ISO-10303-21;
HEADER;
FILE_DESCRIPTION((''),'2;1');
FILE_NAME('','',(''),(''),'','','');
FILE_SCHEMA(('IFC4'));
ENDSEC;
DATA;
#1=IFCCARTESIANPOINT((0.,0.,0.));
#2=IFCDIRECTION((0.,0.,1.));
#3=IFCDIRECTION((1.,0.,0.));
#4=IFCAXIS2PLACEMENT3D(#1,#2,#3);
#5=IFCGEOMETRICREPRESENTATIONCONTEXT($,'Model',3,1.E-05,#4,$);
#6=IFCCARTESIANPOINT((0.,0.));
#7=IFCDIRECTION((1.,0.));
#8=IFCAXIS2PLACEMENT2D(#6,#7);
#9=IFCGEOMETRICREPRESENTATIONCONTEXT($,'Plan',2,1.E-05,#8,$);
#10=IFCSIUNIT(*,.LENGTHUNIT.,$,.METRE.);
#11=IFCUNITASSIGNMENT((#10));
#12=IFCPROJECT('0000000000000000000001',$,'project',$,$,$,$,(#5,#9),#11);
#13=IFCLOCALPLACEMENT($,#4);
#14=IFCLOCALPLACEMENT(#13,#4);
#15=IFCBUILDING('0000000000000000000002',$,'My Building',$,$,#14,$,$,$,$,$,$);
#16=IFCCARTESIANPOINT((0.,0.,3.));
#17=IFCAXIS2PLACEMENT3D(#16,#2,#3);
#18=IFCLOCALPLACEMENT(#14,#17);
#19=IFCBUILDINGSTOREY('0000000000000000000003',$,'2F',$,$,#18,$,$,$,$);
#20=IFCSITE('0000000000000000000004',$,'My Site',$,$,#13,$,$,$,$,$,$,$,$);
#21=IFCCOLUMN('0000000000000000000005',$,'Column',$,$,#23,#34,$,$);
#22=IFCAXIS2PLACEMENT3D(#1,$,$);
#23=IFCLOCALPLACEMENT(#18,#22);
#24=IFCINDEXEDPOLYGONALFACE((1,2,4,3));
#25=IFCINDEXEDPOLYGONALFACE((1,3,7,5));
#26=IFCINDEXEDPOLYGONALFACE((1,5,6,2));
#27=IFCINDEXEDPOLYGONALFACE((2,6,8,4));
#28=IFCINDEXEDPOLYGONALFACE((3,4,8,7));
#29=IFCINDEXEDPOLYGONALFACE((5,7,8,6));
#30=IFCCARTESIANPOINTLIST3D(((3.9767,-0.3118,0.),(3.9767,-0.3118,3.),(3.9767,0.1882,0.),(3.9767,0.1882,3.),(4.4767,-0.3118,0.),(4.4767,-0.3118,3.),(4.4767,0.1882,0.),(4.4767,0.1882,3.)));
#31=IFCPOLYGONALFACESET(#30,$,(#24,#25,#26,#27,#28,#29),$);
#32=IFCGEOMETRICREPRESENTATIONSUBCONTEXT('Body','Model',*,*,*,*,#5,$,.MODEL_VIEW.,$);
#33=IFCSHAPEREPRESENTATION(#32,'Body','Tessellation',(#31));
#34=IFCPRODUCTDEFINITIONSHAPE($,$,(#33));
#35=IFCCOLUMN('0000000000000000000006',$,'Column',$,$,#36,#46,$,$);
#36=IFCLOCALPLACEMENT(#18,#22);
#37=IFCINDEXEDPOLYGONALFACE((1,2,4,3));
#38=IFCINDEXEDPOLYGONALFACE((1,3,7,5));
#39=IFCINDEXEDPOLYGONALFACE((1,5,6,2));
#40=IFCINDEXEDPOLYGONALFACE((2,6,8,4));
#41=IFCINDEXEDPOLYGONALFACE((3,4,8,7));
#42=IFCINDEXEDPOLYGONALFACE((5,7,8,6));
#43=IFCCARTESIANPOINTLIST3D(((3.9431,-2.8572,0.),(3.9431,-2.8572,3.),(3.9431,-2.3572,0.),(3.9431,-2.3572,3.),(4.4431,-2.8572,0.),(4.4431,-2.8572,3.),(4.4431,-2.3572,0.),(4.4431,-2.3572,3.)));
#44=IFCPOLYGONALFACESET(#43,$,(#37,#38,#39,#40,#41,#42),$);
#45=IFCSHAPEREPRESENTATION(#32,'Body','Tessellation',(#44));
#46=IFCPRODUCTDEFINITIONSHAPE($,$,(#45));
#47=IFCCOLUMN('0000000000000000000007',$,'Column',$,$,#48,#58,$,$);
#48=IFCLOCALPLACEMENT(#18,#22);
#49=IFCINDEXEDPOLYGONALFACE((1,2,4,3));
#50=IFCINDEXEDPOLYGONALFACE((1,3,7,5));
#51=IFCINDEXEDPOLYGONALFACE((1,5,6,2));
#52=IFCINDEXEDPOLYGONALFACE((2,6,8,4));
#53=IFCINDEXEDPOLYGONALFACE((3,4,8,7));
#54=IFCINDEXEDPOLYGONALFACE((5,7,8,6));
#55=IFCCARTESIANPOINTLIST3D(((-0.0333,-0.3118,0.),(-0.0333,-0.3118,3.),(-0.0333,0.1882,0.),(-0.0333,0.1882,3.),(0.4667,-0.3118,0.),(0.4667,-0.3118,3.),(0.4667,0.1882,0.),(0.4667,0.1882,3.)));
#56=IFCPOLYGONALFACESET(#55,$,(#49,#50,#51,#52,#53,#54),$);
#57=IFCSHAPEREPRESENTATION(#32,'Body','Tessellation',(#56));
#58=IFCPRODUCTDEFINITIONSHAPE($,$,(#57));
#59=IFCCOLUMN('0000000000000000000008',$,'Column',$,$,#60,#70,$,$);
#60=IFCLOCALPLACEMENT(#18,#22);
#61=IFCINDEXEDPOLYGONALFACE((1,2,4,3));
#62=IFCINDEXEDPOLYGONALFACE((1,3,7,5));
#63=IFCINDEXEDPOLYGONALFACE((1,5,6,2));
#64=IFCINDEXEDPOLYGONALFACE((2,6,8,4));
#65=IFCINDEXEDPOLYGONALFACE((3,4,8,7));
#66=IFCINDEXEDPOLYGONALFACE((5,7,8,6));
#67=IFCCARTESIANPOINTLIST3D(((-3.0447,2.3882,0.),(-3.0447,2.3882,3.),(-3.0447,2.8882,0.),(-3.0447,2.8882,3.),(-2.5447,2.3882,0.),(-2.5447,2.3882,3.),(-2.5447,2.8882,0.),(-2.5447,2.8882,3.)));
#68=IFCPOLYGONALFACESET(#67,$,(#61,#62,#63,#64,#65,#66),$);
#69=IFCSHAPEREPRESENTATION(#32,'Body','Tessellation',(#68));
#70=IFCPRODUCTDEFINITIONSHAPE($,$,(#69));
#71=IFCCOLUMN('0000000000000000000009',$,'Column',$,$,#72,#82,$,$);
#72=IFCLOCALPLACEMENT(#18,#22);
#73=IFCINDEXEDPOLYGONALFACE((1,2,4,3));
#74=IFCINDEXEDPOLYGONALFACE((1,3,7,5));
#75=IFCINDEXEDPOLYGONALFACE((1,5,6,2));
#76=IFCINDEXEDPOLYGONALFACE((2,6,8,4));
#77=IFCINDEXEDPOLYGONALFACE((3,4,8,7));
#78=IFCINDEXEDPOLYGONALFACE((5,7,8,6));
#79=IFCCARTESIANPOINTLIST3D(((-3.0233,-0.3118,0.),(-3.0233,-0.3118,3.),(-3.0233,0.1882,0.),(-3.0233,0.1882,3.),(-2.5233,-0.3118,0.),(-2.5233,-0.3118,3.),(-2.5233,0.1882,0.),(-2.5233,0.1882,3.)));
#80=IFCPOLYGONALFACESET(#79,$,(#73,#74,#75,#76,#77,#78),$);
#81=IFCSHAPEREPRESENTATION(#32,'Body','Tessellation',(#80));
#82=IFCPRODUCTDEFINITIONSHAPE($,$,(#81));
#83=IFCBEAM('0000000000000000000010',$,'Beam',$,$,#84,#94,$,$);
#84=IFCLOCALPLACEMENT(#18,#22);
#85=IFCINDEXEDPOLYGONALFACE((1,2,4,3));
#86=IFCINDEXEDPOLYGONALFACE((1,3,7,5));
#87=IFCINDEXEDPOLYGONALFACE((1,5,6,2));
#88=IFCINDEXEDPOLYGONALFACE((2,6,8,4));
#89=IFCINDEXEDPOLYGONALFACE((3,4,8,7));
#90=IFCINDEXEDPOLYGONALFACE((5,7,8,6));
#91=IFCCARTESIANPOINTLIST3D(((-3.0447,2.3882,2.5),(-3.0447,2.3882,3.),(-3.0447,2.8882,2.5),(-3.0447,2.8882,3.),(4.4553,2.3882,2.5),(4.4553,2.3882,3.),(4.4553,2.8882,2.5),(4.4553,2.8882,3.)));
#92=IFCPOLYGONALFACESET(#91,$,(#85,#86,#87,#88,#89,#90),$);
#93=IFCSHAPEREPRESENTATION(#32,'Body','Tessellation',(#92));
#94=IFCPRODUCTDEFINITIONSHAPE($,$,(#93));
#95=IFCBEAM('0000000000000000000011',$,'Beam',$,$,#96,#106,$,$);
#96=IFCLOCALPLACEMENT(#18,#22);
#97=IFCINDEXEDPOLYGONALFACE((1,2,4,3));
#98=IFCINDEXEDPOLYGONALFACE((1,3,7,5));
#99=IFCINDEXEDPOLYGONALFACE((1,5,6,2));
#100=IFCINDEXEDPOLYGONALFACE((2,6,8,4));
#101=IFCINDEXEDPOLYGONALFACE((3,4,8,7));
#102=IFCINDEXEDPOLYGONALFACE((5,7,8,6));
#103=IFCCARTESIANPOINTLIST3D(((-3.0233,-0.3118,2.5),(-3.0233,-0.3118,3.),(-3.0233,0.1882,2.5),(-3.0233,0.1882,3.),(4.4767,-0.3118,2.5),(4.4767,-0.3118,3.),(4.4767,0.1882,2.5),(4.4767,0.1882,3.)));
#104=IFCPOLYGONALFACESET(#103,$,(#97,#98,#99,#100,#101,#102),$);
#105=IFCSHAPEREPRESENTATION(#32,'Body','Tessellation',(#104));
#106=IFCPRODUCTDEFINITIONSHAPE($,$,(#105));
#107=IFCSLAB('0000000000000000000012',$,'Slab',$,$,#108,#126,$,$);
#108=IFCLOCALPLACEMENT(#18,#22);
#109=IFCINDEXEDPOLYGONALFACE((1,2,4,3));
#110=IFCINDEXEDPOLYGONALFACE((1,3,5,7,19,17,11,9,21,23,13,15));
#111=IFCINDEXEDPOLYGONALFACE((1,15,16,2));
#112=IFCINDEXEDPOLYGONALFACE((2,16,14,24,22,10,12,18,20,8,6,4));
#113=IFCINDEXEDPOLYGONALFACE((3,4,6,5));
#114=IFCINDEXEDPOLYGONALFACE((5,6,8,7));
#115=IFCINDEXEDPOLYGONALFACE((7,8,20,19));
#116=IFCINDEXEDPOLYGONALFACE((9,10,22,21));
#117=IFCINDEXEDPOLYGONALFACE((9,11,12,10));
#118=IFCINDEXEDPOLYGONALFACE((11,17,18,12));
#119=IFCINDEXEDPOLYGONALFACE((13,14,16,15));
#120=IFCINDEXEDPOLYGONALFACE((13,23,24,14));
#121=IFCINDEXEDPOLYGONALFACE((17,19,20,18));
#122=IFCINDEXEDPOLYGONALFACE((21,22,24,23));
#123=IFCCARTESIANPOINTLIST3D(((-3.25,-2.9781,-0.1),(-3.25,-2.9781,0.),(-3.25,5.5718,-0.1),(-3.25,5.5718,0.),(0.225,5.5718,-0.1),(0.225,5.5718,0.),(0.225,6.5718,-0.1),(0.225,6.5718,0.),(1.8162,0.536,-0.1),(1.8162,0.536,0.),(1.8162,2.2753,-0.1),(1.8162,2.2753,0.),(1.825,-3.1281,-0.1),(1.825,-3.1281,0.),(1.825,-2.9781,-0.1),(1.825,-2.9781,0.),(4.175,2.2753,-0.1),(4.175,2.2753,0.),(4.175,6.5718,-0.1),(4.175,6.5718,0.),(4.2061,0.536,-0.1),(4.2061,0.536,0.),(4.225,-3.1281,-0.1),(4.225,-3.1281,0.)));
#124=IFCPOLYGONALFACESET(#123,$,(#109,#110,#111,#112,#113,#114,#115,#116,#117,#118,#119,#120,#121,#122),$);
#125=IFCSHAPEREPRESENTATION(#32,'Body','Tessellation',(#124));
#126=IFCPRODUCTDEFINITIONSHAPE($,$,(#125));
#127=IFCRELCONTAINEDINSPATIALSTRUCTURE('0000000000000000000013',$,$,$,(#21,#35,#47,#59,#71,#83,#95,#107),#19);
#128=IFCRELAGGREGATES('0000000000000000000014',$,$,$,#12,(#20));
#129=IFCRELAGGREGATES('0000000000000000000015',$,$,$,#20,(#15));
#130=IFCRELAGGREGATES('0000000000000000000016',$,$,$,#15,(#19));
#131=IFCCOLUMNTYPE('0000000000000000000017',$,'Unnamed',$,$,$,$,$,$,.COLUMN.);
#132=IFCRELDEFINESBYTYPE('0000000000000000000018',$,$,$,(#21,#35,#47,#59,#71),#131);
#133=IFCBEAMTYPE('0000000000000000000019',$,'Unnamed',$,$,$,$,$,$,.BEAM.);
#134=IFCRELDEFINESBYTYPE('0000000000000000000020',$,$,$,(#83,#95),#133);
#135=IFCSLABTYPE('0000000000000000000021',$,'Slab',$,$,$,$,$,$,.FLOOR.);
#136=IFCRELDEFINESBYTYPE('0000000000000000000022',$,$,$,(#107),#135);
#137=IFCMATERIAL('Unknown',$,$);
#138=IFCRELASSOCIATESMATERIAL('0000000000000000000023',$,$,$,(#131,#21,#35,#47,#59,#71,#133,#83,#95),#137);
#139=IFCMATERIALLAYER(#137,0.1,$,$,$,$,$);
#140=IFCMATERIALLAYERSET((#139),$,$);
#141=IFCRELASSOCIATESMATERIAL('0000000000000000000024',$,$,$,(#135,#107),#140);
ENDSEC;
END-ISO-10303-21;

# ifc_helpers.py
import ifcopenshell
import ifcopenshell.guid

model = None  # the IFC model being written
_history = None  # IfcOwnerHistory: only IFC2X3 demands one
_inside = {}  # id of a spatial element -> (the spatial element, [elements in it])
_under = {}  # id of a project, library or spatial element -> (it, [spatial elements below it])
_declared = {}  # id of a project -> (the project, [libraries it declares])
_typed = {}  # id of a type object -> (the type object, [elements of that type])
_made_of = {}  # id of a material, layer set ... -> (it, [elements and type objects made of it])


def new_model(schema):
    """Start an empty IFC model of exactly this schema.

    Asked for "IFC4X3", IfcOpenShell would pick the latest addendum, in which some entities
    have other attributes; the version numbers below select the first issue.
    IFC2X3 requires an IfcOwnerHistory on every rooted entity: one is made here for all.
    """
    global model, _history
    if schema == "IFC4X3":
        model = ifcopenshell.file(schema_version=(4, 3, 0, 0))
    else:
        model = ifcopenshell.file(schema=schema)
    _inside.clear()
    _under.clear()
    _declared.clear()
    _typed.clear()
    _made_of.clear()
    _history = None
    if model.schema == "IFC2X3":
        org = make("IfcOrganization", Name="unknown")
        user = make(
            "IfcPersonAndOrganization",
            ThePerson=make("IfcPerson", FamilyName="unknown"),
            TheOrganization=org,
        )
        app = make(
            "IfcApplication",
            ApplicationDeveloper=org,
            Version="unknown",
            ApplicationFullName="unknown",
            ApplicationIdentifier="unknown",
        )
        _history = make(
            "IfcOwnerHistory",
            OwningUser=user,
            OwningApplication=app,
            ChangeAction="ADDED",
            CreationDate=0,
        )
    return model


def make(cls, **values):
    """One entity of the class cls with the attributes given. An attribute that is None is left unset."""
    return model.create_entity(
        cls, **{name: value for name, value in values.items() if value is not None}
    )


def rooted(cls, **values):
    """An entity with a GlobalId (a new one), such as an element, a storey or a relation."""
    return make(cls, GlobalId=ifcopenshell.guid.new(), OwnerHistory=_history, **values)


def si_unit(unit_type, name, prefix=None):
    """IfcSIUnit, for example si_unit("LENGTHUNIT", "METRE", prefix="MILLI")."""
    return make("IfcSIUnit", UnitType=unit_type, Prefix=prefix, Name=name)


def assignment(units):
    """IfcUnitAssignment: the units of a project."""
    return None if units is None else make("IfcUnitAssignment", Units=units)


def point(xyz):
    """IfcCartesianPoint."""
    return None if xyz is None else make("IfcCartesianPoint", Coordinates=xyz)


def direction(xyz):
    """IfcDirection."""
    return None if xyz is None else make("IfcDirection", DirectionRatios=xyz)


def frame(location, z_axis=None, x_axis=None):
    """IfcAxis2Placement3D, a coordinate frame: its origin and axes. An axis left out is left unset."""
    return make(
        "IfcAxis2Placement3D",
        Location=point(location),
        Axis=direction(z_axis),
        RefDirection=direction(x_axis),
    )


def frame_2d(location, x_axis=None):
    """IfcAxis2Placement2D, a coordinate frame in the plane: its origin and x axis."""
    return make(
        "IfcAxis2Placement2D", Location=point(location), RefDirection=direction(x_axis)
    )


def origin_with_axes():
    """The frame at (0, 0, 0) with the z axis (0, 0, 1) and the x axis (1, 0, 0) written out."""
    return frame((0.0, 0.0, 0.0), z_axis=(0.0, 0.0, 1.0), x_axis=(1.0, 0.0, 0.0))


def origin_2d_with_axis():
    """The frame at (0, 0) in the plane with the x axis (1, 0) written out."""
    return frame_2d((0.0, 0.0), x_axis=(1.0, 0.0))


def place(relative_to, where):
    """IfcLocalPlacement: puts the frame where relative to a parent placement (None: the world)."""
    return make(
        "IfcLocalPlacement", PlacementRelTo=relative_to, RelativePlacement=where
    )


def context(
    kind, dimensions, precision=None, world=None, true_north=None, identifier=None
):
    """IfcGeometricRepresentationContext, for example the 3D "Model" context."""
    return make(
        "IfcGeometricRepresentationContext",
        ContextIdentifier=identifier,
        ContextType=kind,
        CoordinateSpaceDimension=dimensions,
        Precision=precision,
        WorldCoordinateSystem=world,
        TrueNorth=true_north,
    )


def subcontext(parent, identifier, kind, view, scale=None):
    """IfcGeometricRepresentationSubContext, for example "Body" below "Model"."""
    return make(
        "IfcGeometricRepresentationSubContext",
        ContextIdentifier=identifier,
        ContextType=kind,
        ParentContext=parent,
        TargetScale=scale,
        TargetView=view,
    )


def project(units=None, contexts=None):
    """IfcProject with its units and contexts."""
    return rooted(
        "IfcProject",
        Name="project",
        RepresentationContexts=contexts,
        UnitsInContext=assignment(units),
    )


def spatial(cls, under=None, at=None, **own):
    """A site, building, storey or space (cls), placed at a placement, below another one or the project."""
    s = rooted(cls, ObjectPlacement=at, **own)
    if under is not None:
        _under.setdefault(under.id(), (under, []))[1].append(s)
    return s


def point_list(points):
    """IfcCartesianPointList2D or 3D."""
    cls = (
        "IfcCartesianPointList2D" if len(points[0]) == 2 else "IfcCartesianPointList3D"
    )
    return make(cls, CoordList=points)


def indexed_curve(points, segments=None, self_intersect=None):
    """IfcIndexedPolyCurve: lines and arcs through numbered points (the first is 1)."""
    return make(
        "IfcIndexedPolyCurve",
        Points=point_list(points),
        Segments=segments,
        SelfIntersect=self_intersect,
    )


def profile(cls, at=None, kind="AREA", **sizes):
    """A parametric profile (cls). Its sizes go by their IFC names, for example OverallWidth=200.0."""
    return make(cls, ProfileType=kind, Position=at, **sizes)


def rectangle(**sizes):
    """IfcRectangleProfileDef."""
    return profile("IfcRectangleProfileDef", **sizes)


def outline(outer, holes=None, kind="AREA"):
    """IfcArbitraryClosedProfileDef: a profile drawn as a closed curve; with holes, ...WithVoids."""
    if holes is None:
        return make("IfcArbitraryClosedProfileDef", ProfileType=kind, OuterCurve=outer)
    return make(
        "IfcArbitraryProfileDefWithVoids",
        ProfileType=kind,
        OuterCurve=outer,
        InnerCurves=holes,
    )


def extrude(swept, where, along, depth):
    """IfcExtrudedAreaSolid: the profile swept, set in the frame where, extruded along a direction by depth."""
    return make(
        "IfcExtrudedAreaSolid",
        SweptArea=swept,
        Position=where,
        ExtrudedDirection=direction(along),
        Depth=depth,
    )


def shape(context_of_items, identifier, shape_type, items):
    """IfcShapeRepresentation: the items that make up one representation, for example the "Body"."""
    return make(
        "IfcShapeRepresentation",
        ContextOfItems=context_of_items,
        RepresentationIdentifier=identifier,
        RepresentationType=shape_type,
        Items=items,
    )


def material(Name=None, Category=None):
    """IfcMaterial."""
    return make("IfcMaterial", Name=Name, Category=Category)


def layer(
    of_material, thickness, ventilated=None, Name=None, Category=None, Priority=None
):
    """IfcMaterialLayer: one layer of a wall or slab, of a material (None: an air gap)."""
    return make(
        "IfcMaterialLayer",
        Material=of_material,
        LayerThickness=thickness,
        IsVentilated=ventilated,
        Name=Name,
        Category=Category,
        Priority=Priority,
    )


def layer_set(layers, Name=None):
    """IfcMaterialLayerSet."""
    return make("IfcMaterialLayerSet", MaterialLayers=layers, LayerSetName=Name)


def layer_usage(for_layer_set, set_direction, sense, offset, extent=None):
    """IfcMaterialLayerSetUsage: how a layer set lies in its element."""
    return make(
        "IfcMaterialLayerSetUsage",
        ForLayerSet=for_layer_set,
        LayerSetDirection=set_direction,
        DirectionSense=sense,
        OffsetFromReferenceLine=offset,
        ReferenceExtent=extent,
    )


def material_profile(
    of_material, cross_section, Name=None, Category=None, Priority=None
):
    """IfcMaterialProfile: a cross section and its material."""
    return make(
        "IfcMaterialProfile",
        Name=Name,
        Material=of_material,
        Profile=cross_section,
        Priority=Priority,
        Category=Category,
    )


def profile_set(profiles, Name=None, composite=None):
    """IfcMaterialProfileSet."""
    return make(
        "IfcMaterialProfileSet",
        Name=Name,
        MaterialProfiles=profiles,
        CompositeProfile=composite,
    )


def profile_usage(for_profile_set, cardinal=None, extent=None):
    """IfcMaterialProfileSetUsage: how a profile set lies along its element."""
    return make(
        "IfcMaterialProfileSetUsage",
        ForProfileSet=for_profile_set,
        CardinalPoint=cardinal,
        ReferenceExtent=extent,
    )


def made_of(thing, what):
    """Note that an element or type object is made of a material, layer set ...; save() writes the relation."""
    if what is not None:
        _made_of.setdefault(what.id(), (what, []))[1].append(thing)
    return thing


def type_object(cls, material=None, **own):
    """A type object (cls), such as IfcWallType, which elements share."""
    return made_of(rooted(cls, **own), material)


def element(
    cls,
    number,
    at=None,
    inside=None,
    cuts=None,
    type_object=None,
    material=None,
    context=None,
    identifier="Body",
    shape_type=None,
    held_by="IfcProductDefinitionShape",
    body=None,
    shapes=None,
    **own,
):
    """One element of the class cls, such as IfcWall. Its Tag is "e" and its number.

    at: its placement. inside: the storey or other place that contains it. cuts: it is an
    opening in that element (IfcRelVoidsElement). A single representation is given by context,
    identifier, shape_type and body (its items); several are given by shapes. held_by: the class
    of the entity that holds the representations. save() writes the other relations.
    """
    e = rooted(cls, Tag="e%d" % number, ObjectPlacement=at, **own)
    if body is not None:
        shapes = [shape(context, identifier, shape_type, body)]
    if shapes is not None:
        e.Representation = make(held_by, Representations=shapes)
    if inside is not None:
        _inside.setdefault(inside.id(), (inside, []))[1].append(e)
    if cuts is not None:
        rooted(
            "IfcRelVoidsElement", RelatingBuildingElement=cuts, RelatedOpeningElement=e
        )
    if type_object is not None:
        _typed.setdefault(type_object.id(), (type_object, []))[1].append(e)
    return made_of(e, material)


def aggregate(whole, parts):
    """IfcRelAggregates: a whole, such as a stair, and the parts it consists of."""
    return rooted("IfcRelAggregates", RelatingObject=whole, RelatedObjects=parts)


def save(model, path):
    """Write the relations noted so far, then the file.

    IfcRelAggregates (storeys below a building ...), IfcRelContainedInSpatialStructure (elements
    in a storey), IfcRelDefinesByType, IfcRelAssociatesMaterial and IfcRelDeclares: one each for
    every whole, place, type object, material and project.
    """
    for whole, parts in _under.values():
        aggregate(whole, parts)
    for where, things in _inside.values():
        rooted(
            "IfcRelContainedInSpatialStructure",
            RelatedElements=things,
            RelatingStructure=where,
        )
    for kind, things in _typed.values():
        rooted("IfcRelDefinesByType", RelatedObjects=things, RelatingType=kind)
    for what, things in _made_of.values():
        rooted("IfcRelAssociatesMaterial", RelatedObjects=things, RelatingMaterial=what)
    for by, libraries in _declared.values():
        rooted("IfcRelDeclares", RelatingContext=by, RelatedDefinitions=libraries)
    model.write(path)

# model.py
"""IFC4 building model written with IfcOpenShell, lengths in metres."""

from ifc_helpers import new_model, si_unit, frame, origin_with_axes, origin_2d_with_axis, place, context, subcontext, project, spatial, indexed_curve, rectangle, outline, extrude, material, layer, layer_set, layer_usage, material_profile, profile_set, profile_usage, type_object, element, save


model = new_model("IFC4")

# Units and contexts
model_context = context("Model", 3, precision=1e-05, world=origin_with_axes())
plan_context = context("Plan", 2, precision=1e-05, world=origin_2d_with_axis())
body_context_1 = subcontext(model_context, "Body", "Model", "MODEL_VIEW")
ifc_project = project(units=[si_unit("LENGTHUNIT", "METRE")], contexts=[model_context, plan_context])

# Site, building, storey
site_placement = place(None, origin_with_axes())
site = spatial("IfcSite", under=ifc_project, at=site_placement, Name="My Site")
building_placement = place(site_placement, origin_with_axes())
building = spatial("IfcBuilding", under=site, at=building_placement, Name="My Building")
storey_placement = place(building_placement, frame((0.0, 0.0, 3.0), z_axis=(0.0, 0.0, 1.0), x_axis=(1.0, 0.0, 0.0)))
storey = spatial("IfcBuildingStorey", under=building, at=storey_placement, Name="2F")

# Columns
ifc_material = material(Name="Unknown")
ifc_material_profile_1 = material_profile(ifc_material, rectangle(XDim=0.5, YDim=0.5))
ifc_profile_set_1 = profile_set([ifc_material_profile_1])
ifc_profile_usage_1 = profile_usage(ifc_profile_set_1, cardinal=5)
column_type = type_object("IfcColumnType", Name="Unnamed", PredefinedType="COLUMN", material=ifc_profile_set_1)
column_1_placement = place(storey_placement, frame((4.2267, -0.0618, 0.0), z_axis=(0.0, 0.0, 1.0), x_axis=(1.0, 0.0, 0.0)))
element("IfcColumn", 1, at=column_1_placement, inside=storey, type_object=column_type, material=ifc_profile_usage_1, Name="Column", context=body_context_1, shape_type="SweptSolid", body=[
    extrude(rectangle(XDim=0.5, YDim=0.5), origin_with_axes(), (0.0, 0.0, 1.0), 3.0),
])
ifc_profile_usage_2 = profile_usage(ifc_profile_set_1, cardinal=5)
column_2_placement = place(storey_placement, frame((4.1931, -2.6072, 0.0), z_axis=(0.0, 0.0, 1.0), x_axis=(1.0, 0.0, 0.0)))
element("IfcColumn", 2, at=column_2_placement, inside=storey, type_object=column_type, material=ifc_profile_usage_2, Name="Column", context=body_context_1, shape_type="SweptSolid", body=[
    extrude(rectangle(XDim=0.5, YDim=0.5), origin_with_axes(), (0.0, 0.0, 1.0), 3.0),
])
ifc_profile_usage_3 = profile_usage(ifc_profile_set_1, cardinal=5)
column_3_placement = place(storey_placement, frame((0.2167, -0.0618, 0.0), z_axis=(0.0, 0.0, 1.0), x_axis=(1.0, 0.0, 0.0)))
element("IfcColumn", 3, at=column_3_placement, inside=storey, type_object=column_type, material=ifc_profile_usage_3, Name="Column", context=body_context_1, shape_type="SweptSolid", body=[
    extrude(rectangle(XDim=0.5, YDim=0.5), origin_with_axes(), (0.0, 0.0, 1.0), 3.0),
])
ifc_profile_usage_4 = profile_usage(ifc_profile_set_1, cardinal=5)
column_4_placement = place(storey_placement, frame((-2.7947, 2.6382, 0.0), z_axis=(0.0, 0.0, 1.0), x_axis=(1.0, 0.0, 0.0)))
element("IfcColumn", 4, at=column_4_placement, inside=storey, type_object=column_type, material=ifc_profile_usage_4, Name="Column", context=body_context_1, shape_type="SweptSolid", body=[
    extrude(rectangle(XDim=0.5, YDim=0.5), origin_with_axes(), (0.0, 0.0, 1.0), 3.0),
])
ifc_profile_usage_5 = profile_usage(ifc_profile_set_1, cardinal=5)
column_5_placement = place(storey_placement, frame((-2.7733, -0.0618, 0.0), z_axis=(0.0, 0.0, 1.0), x_axis=(1.0, 0.0, 0.0)))
element("IfcColumn", 5, at=column_5_placement, inside=storey, type_object=column_type, material=ifc_profile_usage_5, Name="Column", context=body_context_1, shape_type="SweptSolid", body=[
    extrude(rectangle(XDim=0.5, YDim=0.5), origin_with_axes(), (0.0, 0.0, 1.0), 3.0),
])

# Beams
ifc_material_profile_2 = material_profile(ifc_material, rectangle(XDim=0.5, YDim=0.5))
ifc_profile_set_2 = profile_set([ifc_material_profile_2])
ifc_profile_usage_6 = profile_usage(ifc_profile_set_2, cardinal=7)
beam_type = type_object("IfcBeamType", Name="Unnamed", PredefinedType="BEAM", material=ifc_profile_set_2)
beam_1_placement = place(storey_placement, frame((4.4553, 2.3882, 3.0), z_axis=(-1.0, 0.0, 0.0), x_axis=(0.0, -1.0, 0.0)))
element("IfcBeam", 6, at=beam_1_placement, inside=storey, type_object=beam_type, material=ifc_profile_usage_6, Name="Beam", context=body_context_1, shape_type="SweptSolid", body=[
    extrude(rectangle(XDim=0.5, YDim=0.5), frame((-0.25, -0.25, 0.0), z_axis=(0.0, 0.0, 1.0), x_axis=(1.0, 0.0, 0.0)), (0.0, 0.0, 1.0), 7.5),
])
ifc_profile_usage_7 = profile_usage(ifc_profile_set_2, cardinal=7)
beam_2_placement = place(storey_placement, frame((4.4767, -0.3118, 3.0), z_axis=(-1.0, 0.0, 0.0), x_axis=(0.0, -1.0, 0.0)))
element("IfcBeam", 7, at=beam_2_placement, inside=storey, type_object=beam_type, material=ifc_profile_usage_7, Name="Beam", context=body_context_1, shape_type="SweptSolid", body=[
    extrude(rectangle(XDim=0.5, YDim=0.5), frame((-0.25, -0.25, 0.0), z_axis=(0.0, 0.0, 1.0), x_axis=(1.0, 0.0, 0.0)), (0.0, 0.0, 1.0), 7.5),
])

# Slab
ifc_layer_1 = layer(ifc_material, 0.1)
ifc_layer_set_1 = layer_set([ifc_layer_1])
ifc_layer_usage_1 = layer_usage(ifc_layer_set_1, "AXIS3", "POSITIVE", -0.1)
slab_type = type_object("IfcSlabType", Name="Slab", PredefinedType="FLOOR", material=ifc_layer_set_1)
slab_placement = place(storey_placement, frame((4.225, -3.1281, 0.0), z_axis=(0.0, 0.0, 1.0), x_axis=(1.0, 0.0, 0.0)))
element("IfcSlab", 8, at=slab_placement, inside=storey, type_object=slab_type, material=ifc_layer_usage_1, Name="Slab", context=body_context_1, shape_type="SweptSolid", body=[
    extrude(outline(indexed_curve([(-0.0189, 3.6641), (-2.4088, 3.6641), (-2.4088, 5.4034), (-0.05, 5.4034), (-0.05, 9.7), (-4.0, 9.7), (-4.0, 8.7), (-7.475, 8.7), (-7.475, 0.15), (-2.4, 0.15), (-2.4, 0.0), (0.0, 0.0), (-0.0189, 3.6641)])), frame((0.0, 0.0, -0.1), z_axis=(0.0, 0.0, 1.0), x_axis=(1.0, 0.0, 0.0)), (0.0, 0.0, 1.0), 0.1),
])

save(model, "model.ifc")
